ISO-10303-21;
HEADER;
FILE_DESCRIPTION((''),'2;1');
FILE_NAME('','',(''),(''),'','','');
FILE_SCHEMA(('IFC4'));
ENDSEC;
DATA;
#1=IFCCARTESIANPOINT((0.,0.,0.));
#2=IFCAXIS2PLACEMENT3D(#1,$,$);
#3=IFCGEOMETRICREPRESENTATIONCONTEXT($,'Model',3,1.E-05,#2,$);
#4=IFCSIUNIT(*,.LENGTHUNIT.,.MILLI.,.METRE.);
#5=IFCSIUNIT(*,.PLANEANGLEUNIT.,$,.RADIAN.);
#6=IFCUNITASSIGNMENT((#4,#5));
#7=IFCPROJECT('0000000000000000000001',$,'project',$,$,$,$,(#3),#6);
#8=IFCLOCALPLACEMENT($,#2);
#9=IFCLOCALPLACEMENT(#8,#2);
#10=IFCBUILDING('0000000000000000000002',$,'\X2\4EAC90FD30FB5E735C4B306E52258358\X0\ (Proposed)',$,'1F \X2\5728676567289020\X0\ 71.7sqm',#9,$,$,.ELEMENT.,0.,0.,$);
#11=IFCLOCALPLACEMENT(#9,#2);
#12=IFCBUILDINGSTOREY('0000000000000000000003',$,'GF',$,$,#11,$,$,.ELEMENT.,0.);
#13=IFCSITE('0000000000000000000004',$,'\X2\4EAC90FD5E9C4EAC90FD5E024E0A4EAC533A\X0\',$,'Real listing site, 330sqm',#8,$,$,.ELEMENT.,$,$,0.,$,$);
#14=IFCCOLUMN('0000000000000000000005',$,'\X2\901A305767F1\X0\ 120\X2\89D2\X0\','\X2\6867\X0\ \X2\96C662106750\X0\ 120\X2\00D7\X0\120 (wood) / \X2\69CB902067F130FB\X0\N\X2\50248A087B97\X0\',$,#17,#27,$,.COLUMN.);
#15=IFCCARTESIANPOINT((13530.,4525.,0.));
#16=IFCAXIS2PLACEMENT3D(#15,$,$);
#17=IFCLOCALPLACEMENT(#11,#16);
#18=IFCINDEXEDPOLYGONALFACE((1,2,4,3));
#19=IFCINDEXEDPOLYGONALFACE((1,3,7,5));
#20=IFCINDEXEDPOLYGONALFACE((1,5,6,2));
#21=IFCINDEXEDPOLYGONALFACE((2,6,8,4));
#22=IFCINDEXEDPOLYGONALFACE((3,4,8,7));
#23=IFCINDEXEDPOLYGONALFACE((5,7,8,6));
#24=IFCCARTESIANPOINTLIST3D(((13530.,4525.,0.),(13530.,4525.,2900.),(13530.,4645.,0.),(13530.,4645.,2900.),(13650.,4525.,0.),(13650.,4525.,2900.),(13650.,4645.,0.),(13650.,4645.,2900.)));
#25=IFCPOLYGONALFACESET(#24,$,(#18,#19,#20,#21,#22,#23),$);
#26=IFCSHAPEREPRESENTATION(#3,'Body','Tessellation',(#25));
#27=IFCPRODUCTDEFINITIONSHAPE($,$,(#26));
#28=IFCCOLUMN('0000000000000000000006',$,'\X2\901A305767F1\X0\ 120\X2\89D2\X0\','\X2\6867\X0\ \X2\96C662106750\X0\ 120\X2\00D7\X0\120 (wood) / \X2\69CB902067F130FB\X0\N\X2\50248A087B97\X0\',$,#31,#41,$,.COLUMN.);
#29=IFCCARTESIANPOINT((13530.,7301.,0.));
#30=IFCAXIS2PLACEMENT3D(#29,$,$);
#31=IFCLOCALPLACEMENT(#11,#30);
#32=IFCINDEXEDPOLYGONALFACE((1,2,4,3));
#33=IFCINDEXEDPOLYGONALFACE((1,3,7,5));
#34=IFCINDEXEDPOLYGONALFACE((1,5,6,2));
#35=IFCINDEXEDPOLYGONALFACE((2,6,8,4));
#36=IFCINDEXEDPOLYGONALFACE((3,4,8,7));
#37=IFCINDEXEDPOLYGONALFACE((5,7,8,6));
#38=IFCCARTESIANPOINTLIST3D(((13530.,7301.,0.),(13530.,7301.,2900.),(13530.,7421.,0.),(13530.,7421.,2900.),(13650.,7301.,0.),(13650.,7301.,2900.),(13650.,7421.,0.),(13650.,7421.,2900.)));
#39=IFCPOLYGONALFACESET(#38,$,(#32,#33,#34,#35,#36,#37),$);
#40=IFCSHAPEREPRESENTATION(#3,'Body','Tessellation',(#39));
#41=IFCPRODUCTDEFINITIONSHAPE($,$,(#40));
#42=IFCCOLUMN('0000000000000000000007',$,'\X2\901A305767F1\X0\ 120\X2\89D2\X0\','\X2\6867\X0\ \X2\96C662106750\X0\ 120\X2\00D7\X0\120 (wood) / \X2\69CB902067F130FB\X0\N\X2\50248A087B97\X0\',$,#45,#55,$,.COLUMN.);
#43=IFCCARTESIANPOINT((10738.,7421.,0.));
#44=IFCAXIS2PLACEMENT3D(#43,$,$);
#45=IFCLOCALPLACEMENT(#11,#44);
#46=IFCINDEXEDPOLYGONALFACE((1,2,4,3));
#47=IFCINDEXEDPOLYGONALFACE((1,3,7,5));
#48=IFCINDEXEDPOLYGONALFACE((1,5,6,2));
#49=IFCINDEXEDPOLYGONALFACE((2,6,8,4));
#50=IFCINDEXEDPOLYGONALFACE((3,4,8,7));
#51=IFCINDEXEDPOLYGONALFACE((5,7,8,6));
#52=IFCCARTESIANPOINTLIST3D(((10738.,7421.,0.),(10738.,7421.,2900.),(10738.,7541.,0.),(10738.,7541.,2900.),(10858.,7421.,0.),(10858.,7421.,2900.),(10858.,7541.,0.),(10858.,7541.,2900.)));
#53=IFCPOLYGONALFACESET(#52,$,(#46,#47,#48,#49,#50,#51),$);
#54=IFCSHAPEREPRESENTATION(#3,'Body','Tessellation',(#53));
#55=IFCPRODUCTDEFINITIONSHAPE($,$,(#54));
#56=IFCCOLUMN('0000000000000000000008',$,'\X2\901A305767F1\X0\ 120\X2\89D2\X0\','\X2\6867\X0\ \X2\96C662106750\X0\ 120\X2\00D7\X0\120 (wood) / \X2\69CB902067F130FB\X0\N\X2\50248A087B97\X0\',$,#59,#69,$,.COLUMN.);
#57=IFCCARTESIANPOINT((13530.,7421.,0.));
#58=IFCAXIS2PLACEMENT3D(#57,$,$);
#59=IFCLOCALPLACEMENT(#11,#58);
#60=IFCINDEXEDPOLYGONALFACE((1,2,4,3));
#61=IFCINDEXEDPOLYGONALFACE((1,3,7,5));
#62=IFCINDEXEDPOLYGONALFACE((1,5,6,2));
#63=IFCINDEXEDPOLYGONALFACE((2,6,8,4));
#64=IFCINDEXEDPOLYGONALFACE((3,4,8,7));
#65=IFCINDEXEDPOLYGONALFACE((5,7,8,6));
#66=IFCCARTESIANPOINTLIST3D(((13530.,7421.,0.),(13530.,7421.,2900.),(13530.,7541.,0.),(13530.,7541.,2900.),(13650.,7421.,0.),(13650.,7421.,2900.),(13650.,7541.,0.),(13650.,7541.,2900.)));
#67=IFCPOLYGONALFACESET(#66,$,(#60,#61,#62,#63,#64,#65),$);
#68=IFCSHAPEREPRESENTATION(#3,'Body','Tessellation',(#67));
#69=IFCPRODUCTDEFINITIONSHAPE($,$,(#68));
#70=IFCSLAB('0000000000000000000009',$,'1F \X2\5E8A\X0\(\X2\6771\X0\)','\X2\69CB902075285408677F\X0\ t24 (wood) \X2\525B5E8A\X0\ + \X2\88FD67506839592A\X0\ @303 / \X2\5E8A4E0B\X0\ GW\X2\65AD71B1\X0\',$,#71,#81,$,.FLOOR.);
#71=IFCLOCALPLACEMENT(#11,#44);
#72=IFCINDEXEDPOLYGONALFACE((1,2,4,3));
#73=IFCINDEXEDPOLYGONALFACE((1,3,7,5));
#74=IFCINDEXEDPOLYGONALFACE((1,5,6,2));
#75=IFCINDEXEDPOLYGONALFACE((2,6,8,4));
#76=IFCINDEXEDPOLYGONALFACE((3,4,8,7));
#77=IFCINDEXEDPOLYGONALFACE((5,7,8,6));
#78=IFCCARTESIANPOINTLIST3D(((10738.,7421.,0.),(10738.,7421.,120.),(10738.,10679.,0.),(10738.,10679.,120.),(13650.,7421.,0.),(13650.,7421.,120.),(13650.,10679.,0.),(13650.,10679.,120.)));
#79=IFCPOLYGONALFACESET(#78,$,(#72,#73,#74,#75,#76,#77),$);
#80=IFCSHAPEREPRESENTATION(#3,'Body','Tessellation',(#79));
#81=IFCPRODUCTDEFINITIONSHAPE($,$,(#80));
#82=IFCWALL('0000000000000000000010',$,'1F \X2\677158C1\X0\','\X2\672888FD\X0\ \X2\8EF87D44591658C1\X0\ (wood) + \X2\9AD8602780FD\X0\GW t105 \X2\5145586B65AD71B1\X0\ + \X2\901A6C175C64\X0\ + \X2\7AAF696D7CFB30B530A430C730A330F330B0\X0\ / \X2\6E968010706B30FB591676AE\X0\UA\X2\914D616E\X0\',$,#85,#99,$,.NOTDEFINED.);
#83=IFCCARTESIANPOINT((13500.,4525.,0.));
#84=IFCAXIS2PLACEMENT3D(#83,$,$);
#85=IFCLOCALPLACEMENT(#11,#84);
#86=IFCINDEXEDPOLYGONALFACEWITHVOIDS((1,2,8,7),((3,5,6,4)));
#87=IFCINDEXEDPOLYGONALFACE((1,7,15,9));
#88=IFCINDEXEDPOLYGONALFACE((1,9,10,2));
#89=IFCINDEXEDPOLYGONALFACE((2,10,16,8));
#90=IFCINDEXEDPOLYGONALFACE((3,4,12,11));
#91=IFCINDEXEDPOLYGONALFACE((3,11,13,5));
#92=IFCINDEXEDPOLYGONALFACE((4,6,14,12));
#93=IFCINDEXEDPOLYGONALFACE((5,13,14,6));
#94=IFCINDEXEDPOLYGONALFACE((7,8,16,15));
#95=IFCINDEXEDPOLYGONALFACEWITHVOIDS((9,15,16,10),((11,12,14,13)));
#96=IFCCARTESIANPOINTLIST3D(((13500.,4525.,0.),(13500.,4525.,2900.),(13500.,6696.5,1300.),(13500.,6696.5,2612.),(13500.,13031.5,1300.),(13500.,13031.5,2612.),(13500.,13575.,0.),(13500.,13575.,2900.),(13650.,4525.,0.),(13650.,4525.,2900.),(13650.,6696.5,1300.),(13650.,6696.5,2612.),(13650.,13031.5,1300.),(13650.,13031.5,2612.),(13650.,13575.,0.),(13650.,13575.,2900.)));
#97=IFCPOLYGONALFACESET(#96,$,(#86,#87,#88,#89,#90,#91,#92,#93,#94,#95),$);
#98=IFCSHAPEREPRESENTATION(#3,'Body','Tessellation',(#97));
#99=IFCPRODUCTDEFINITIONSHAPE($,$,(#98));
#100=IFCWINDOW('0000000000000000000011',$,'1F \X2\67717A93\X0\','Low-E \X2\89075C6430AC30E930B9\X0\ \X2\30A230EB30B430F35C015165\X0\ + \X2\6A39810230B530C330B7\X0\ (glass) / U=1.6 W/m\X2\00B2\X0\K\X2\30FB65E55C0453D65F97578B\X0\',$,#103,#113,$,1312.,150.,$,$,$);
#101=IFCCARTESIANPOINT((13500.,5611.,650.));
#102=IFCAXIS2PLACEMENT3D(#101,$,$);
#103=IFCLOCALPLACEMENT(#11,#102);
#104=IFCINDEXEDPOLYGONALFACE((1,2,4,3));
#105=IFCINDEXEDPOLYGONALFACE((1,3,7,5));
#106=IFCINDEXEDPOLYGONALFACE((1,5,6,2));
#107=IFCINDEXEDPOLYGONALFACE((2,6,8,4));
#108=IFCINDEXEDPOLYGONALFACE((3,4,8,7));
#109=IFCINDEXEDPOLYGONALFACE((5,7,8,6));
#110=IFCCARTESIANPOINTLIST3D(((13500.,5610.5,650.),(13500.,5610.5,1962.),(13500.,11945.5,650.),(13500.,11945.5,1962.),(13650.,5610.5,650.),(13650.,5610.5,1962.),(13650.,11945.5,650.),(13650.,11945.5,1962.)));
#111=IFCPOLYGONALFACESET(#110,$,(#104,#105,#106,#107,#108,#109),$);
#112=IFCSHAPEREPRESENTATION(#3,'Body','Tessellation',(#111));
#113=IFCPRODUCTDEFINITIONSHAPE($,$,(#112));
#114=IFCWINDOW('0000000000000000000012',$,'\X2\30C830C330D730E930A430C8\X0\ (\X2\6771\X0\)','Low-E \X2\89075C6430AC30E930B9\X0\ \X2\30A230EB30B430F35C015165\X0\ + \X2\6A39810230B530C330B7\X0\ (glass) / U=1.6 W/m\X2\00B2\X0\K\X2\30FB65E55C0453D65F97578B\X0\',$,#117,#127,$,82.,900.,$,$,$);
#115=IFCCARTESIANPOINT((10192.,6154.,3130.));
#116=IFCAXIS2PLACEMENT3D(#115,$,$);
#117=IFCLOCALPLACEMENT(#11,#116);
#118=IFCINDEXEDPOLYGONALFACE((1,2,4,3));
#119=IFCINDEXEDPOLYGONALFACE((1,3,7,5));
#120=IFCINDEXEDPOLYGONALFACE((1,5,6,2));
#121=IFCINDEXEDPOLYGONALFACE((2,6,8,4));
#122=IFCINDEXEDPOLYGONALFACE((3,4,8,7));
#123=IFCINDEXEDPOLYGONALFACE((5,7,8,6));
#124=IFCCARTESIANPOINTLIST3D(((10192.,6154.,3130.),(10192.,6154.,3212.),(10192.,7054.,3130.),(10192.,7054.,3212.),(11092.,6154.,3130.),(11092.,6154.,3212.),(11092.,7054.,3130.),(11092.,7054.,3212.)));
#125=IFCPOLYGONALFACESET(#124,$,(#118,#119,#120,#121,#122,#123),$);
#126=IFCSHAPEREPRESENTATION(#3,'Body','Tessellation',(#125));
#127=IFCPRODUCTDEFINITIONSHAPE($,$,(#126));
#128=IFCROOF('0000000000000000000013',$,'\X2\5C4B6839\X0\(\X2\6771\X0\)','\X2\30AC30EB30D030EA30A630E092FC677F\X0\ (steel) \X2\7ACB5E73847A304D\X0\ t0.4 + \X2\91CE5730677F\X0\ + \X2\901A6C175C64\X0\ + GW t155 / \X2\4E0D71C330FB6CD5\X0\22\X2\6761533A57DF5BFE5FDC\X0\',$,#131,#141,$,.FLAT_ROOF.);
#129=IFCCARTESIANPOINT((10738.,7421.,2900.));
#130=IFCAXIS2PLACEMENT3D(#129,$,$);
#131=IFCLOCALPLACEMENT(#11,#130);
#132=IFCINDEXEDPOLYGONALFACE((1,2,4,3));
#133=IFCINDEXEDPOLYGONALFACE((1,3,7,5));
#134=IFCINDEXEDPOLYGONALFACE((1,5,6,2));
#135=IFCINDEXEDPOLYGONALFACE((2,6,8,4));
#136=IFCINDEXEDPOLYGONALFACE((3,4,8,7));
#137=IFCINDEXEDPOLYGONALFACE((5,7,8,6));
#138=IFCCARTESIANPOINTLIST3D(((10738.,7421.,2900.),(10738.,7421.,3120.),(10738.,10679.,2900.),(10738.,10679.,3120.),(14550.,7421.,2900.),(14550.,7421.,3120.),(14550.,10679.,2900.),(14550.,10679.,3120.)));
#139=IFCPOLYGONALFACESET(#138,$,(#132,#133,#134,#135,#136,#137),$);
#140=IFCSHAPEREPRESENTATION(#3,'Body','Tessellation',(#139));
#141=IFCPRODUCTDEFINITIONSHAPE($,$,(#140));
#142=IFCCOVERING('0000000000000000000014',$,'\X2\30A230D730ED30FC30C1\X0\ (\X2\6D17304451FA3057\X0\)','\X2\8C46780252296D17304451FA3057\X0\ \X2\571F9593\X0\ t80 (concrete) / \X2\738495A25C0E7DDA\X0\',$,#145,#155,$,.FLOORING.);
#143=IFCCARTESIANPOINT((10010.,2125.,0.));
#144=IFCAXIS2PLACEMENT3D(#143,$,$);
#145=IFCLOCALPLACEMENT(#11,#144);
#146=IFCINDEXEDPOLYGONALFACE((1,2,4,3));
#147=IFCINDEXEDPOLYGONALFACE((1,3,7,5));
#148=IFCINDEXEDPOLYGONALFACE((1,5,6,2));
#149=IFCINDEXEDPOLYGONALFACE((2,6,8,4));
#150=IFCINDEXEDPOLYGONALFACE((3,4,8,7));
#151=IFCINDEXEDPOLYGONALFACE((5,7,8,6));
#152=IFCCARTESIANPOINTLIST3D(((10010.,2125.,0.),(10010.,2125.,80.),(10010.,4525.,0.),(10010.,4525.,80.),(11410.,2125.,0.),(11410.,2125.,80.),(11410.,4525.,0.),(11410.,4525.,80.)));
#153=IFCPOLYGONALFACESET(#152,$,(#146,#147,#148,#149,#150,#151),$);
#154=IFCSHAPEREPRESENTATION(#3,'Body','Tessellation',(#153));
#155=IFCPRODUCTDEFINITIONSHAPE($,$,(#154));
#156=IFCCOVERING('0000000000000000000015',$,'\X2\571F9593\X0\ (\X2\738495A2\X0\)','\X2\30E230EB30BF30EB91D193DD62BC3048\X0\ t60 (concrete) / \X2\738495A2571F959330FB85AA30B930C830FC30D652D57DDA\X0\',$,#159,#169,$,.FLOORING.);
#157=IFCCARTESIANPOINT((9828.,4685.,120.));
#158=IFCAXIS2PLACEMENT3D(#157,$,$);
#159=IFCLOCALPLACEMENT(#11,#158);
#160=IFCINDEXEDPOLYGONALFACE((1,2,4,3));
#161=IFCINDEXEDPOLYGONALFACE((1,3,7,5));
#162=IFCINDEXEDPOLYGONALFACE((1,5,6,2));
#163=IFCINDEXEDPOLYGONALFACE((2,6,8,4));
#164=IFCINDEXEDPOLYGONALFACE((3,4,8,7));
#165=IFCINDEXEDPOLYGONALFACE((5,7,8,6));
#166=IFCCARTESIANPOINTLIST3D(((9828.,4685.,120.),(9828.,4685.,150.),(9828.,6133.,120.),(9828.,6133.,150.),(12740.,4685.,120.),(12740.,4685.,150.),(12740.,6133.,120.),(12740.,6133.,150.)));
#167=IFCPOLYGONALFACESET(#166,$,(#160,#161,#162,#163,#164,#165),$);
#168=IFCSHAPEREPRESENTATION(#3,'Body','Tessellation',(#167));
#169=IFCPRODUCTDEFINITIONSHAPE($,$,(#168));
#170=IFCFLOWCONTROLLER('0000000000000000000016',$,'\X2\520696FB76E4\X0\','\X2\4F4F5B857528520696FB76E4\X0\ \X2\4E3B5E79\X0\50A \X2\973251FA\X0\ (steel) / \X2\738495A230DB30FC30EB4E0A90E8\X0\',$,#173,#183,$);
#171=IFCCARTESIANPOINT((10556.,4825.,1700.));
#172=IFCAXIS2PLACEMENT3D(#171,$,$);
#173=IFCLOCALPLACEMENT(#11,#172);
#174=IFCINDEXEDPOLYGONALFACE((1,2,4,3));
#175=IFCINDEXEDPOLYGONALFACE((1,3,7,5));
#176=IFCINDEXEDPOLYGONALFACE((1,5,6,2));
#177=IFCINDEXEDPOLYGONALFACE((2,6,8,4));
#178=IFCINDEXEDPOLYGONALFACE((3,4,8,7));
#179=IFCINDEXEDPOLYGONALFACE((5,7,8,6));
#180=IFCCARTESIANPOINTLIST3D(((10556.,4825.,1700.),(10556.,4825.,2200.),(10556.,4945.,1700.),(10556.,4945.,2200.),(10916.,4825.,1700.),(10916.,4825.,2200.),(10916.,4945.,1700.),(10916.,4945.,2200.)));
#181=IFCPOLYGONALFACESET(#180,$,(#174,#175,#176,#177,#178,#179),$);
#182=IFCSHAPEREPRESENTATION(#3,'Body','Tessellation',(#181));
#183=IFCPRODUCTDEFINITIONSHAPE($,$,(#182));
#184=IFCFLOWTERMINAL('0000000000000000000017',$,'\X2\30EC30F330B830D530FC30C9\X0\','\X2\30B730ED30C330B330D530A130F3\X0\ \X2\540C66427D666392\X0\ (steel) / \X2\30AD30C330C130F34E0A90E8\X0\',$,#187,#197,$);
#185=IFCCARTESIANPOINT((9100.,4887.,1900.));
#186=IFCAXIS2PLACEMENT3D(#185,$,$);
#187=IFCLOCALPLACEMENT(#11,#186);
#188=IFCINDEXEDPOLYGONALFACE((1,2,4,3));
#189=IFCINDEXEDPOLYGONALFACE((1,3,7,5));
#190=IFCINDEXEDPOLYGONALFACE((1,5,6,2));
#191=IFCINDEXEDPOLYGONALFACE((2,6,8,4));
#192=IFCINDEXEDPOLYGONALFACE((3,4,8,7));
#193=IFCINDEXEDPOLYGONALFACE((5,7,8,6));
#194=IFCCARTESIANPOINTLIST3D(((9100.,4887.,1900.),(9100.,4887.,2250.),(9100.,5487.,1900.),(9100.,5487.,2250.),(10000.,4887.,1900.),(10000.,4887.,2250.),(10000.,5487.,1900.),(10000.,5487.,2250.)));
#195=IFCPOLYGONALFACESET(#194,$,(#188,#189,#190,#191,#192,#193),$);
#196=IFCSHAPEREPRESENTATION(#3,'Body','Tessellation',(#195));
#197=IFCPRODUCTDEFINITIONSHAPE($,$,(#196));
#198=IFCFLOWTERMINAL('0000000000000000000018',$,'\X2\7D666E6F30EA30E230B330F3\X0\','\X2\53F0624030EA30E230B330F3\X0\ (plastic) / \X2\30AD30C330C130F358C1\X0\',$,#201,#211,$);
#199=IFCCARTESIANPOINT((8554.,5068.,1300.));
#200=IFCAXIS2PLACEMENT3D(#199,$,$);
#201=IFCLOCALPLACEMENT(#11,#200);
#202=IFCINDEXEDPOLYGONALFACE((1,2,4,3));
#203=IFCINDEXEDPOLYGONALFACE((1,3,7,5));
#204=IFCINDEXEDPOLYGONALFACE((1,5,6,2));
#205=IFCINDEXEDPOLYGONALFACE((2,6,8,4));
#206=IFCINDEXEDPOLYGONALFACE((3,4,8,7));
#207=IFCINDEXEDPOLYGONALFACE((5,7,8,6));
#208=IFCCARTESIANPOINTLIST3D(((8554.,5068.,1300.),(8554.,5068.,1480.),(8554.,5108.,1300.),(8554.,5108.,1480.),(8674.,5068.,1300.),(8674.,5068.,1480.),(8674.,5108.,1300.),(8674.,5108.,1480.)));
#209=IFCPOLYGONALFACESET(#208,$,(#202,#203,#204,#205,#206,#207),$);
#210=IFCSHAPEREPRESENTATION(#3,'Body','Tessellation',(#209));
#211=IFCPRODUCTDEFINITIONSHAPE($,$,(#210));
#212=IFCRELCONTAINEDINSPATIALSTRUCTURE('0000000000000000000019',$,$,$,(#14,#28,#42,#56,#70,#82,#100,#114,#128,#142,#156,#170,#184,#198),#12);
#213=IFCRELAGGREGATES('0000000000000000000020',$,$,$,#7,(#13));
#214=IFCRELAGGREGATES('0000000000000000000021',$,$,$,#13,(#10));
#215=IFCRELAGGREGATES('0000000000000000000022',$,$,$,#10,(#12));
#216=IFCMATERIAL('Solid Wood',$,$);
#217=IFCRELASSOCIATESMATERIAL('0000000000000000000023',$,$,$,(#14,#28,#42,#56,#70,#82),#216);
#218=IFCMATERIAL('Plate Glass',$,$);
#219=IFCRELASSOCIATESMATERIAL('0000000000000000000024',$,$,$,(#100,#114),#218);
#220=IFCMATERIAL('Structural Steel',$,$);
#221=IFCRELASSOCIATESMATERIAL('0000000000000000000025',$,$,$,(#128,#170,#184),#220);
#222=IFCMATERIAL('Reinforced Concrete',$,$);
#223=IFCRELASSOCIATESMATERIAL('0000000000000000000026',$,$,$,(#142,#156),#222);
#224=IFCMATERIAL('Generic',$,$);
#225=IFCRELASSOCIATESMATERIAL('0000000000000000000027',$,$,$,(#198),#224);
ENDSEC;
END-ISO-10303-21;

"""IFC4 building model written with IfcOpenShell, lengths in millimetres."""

from ifc_helpers import new_model, si_unit, frame, frame_2d, origin, place, context, project, spatial, rectangle, extrude, material, element, fill, save


model = new_model("IFC4")

# Units and contexts
model_context = context("Model", 3, precision=1e-05, world=origin())
ifc_project = project(units=[si_unit("LENGTHUNIT", "METRE", prefix="MILLI"), si_unit("PLANEANGLEUNIT", "RADIAN")], contexts=[model_context])

# Site, building, storey
site_placement = place(None, origin())
site = spatial("IfcSite", under=ifc_project, at=site_placement, Name="京都府京都市上京区", ObjectType="Real listing site, 330sqm", CompositionType="ELEMENT", RefElevation=0.0)
building_placement = place(site_placement, origin())
building = spatial("IfcBuilding", under=site, at=building_placement, Name="京都・平屋の別荘 (Proposed)", ObjectType="1F 在来木造 71.7sqm", CompositionType="ELEMENT", ElevationOfRefHeight=0.0, ElevationOfTerrain=0.0)
storey_placement = place(building_placement, origin())
storey = spatial("IfcBuildingStorey", under=building, at=storey_placement, Name="GF", CompositionType="ELEMENT", Elevation=0.0)

# Columns
ifc_material_1 = material(Name="Solid Wood")
column_1_placement = place(storey_placement, frame((13530.0, 4525.0, 0.0)))
element("IfcColumn", 1, at=column_1_placement, inside=storey, material=ifc_material_1, Name="通し柱 120角", Description="桧 集成材 120×120 (wood) / 構造柱・N値計算", PredefinedType="COLUMN", context=model_context, shape_type="SweptSolid", body=[
    extrude(rectangle(XDim=120.0, YDim=120.0, at=frame_2d((60.0, 60.0))), frame((13530.0, 4525.0, 0.0)), (0.0, 0.0, 1.0), 2900.0),
])
column_2_placement = place(storey_placement, frame((13530.0, 7301.0, 0.0)))
element("IfcColumn", 2, at=column_2_placement, inside=storey, material=ifc_material_1, Name="通し柱 120角", Description="桧 集成材 120×120 (wood) / 構造柱・N値計算", PredefinedType="COLUMN", context=model_context, shape_type="SweptSolid", body=[
    extrude(rectangle(XDim=120.0, YDim=120.0, at=frame_2d((60.0, 60.0))), frame((13530.0, 7301.0, 0.0)), (0.0, 0.0, 1.0), 2900.0),
])
column_3_placement = place(storey_placement, frame((10738.0, 7421.0, 0.0)))
element("IfcColumn", 3, at=column_3_placement, inside=storey, material=ifc_material_1, Name="通し柱 120角", Description="桧 集成材 120×120 (wood) / 構造柱・N値計算", PredefinedType="COLUMN", context=model_context, shape_type="SweptSolid", body=[
    extrude(rectangle(XDim=120.0, YDim=120.0, at=frame_2d((60.0, 60.0))), frame((10738.0, 7421.0, 0.0)), (0.0, 0.0, 1.0), 2900.0),
])
column_4_placement = place(storey_placement, frame((13530.0, 7421.0, 0.0)))
element("IfcColumn", 4, at=column_4_placement, inside=storey, material=ifc_material_1, Name="通し柱 120角", Description="桧 集成材 120×120 (wood) / 構造柱・N値計算", PredefinedType="COLUMN", context=model_context, shape_type="SweptSolid", body=[
    extrude(rectangle(XDim=120.0, YDim=120.0, at=frame_2d((60.0, 60.0))), frame((13530.0, 7421.0, 0.0)), (0.0, 0.0, 1.0), 2900.0),
])

# Slab
slab_placement = place(storey_placement, frame((10738.0, 7421.0, 0.0)))
element("IfcSlab", 5, at=slab_placement, inside=storey, material=ifc_material_1, Name="1F 床(東)", Description="構造用合板 t24 (wood) 剛床 + 製材根太 @303 / 床下 GW断熱", PredefinedType="FLOOR", context=model_context, shape_type="SweptSolid", body=[
    extrude(rectangle(XDim=2912.0, YDim=3258.0, at=frame_2d((1456.0, 1629.0))), frame((10738.0, 7421.0, 0.0)), (0.0, 0.0, 1.0), 120.0),
])

# Wall, opening, window
wall_1_placement = place(storey_placement, frame((13500.0, 4525.0, 0.0)))
wall_1 = element("IfcWall", 6, at=wall_1_placement, inside=storey, material=ifc_material_1, Name="1F 東壁", Description="木製 軸組外壁 (wood) + 高性能GW t105 充填断熱 + 通気層 + 窯業系サイディング / 準耐火・外皮UA配慮", PredefinedType="NOTDEFINED", context=model_context, shape_type="SweptSolid", body=[
    extrude(rectangle(XDim=150.0, YDim=9050.0, at=frame_2d((75.0, 4525.0))), frame((13500.0, 4525.0, 0.0)), (0.0, 0.0, 1.0), 2900.0),
])
opening_placement = place(storey_placement, frame((13500.0, 5611.0, 650.0)))
opening = element("IfcOpeningElement", 7, at=opening_placement, cuts=wall_1, PredefinedType="NOTDEFINED", context=model_context, shape_type="SweptSolid", body=[
    extrude(rectangle(XDim=150.0, YDim=6335.0, at=frame_2d((75.0, 3167.0))), frame((13500.0, 5611.0, 650.0)), (0.0, 0.0, 1.0), 1312.0),
])
ifc_material_2 = material(Name="Plate Glass")
window_1_placement = place(storey_placement, frame((13500.0, 5611.0, 650.0)))
window_1 = element("IfcWindow", 8, at=window_1_placement, inside=storey, material=ifc_material_2, Name="1F 東窓", Description="Low-E 複層ガラス アルゴン封入 + 樹脂サッシ (glass) / U=1.6 W/m²K・日射取得型", OverallHeight=1312.0, OverallWidth=150.0, context=model_context, shape_type="SweptSolid", body=[
    extrude(rectangle(XDim=150.0, YDim=6335.0, at=frame_2d((75.0, 3167.0))), frame((13500.0, 5611.0, 650.0)), (0.0, 0.0, 1.0), 1312.0),
])
fill(opening, window_1)

# Window
window_2_placement = place(storey_placement, frame((10192.0, 6154.0, 3130.0)))
element("IfcWindow", 9, at=window_2_placement, inside=storey, material=ifc_material_2, Name="トップライト (東)", Description="Low-E 複層ガラス アルゴン封入 + 樹脂サッシ (glass) / U=1.6 W/m²K・日射取得型", OverallHeight=82.0, OverallWidth=900.0, context=model_context, shape_type="SweptSolid", body=[
    extrude(rectangle(XDim=900.0, YDim=900.0, at=frame_2d((450.0, 450.0))), frame((10192.0, 6154.0, 3130.0)), (0.0, 0.0, 1.0), 82.0),
])

# Roof
ifc_material_3 = material(Name="Structural Steel")
roof_placement = place(storey_placement, frame((10738.0, 7421.0, 2900.0)))
element("IfcRoof", 10, at=roof_placement, inside=storey, material=ifc_material_3, Name="屋根(東)", Description="ガルバリウム鋼板 (steel) 立平葺き t0.4 + 野地板 + 通気層 + GW t155 / 不燃・法22条区域対応", PredefinedType="FLAT_ROOF", context=model_context, shape_type="SweptSolid", body=[
    extrude(rectangle(XDim=3812.0, YDim=3258.0, at=frame_2d((1906.0, 1629.0))), frame((10738.0, 7421.0, 2900.0)), (0.0, 0.0, 1.0), 220.0),
])

# Coverings
ifc_material_4 = material(Name="Reinforced Concrete")
covering_1_placement = place(storey_placement, frame((10010.0, 2125.0, 0.0)))
element("IfcCovering", 11, at=covering_1_placement, inside=storey, material=ifc_material_4, Name="アプローチ (洗い出し)", Description="豆砂利洗い出し 土間 t80 (concrete) / 玄関導線", PredefinedType="FLOORING", context=model_context, shape_type="SweptSolid", body=[
    extrude(rectangle(XDim=1400.0, YDim=2400.0, at=frame_2d((700.0, 1200.0))), frame((10010.0, 2125.0, 0.0)), (0.0, 0.0, 1.0), 80.0),
])
covering_2_placement = place(storey_placement, frame((9828.0, 4685.0, 120.0)))
element("IfcCovering", 12, at=covering_2_placement, inside=storey, material=ifc_material_4, Name="土間 (玄関)", Description="モルタル金鏝押え t60 (concrete) / 玄関土間・薪ストーブ動線", PredefinedType="FLOORING", context=model_context, shape_type="SweptSolid", body=[
    extrude(rectangle(XDim=2912.0, YDim=1448.0, at=frame_2d((1456.0, 724.0))), frame((9828.0, 4685.0, 120.0)), (0.0, 0.0, 1.0), 30.0),
])

# Flow controller
flow_controller_placement = place(storey_placement, frame((10556.0, 4825.0, 1700.0)))
element("IfcFlowController", 13, at=flow_controller_placement, inside=storey, material=ifc_material_3, Name="分電盤", Description="住宅用分電盤 主幹50A 露出 (steel) / 玄関ホール上部", context=model_context, shape_type="SweptSolid", body=[
    extrude(rectangle(XDim=360.0, YDim=120.0, at=frame_2d((180.0, 60.0))), frame((10556.0, 4825.0, 1700.0)), (0.0, 0.0, 1.0), 500.0),
])

# Flow terminals
flow_terminal_1_placement = place(storey_placement, frame((9100.0, 4887.0, 1900.0)))
element("IfcFlowTerminal", 14, at=flow_terminal_1_placement, inside=storey, material=ifc_material_3, Name="レンジフード", Description="シロッコファン 同時給排 (steel) / キッチン上部", context=model_context, shape_type="SweptSolid", body=[
    extrude(rectangle(XDim=900.0, YDim=600.0, at=frame_2d((450.0, 300.0))), frame((9100.0, 4887.0, 1900.0)), (0.0, 0.0, 1.0), 350.0),
])
ifc_material_5 = material(Name="Generic")
flow_terminal_2_placement = place(storey_placement, frame((8554.0, 5068.0, 1300.0)))
element("IfcFlowTerminal", 15, at=flow_terminal_2_placement, inside=storey, material=ifc_material_5, Name="給湯リモコン", Description="台所リモコン (plastic) / キッチン壁", context=model_context, shape_type="SweptSolid", body=[
    extrude(rectangle(XDim=120.0, YDim=40.0, at=frame_2d((60.0, 20.0))), frame((8554.0, 5068.0, 1300.0)), (0.0, 0.0, 1.0), 180.0),
])

save(model, "model.ifc")
